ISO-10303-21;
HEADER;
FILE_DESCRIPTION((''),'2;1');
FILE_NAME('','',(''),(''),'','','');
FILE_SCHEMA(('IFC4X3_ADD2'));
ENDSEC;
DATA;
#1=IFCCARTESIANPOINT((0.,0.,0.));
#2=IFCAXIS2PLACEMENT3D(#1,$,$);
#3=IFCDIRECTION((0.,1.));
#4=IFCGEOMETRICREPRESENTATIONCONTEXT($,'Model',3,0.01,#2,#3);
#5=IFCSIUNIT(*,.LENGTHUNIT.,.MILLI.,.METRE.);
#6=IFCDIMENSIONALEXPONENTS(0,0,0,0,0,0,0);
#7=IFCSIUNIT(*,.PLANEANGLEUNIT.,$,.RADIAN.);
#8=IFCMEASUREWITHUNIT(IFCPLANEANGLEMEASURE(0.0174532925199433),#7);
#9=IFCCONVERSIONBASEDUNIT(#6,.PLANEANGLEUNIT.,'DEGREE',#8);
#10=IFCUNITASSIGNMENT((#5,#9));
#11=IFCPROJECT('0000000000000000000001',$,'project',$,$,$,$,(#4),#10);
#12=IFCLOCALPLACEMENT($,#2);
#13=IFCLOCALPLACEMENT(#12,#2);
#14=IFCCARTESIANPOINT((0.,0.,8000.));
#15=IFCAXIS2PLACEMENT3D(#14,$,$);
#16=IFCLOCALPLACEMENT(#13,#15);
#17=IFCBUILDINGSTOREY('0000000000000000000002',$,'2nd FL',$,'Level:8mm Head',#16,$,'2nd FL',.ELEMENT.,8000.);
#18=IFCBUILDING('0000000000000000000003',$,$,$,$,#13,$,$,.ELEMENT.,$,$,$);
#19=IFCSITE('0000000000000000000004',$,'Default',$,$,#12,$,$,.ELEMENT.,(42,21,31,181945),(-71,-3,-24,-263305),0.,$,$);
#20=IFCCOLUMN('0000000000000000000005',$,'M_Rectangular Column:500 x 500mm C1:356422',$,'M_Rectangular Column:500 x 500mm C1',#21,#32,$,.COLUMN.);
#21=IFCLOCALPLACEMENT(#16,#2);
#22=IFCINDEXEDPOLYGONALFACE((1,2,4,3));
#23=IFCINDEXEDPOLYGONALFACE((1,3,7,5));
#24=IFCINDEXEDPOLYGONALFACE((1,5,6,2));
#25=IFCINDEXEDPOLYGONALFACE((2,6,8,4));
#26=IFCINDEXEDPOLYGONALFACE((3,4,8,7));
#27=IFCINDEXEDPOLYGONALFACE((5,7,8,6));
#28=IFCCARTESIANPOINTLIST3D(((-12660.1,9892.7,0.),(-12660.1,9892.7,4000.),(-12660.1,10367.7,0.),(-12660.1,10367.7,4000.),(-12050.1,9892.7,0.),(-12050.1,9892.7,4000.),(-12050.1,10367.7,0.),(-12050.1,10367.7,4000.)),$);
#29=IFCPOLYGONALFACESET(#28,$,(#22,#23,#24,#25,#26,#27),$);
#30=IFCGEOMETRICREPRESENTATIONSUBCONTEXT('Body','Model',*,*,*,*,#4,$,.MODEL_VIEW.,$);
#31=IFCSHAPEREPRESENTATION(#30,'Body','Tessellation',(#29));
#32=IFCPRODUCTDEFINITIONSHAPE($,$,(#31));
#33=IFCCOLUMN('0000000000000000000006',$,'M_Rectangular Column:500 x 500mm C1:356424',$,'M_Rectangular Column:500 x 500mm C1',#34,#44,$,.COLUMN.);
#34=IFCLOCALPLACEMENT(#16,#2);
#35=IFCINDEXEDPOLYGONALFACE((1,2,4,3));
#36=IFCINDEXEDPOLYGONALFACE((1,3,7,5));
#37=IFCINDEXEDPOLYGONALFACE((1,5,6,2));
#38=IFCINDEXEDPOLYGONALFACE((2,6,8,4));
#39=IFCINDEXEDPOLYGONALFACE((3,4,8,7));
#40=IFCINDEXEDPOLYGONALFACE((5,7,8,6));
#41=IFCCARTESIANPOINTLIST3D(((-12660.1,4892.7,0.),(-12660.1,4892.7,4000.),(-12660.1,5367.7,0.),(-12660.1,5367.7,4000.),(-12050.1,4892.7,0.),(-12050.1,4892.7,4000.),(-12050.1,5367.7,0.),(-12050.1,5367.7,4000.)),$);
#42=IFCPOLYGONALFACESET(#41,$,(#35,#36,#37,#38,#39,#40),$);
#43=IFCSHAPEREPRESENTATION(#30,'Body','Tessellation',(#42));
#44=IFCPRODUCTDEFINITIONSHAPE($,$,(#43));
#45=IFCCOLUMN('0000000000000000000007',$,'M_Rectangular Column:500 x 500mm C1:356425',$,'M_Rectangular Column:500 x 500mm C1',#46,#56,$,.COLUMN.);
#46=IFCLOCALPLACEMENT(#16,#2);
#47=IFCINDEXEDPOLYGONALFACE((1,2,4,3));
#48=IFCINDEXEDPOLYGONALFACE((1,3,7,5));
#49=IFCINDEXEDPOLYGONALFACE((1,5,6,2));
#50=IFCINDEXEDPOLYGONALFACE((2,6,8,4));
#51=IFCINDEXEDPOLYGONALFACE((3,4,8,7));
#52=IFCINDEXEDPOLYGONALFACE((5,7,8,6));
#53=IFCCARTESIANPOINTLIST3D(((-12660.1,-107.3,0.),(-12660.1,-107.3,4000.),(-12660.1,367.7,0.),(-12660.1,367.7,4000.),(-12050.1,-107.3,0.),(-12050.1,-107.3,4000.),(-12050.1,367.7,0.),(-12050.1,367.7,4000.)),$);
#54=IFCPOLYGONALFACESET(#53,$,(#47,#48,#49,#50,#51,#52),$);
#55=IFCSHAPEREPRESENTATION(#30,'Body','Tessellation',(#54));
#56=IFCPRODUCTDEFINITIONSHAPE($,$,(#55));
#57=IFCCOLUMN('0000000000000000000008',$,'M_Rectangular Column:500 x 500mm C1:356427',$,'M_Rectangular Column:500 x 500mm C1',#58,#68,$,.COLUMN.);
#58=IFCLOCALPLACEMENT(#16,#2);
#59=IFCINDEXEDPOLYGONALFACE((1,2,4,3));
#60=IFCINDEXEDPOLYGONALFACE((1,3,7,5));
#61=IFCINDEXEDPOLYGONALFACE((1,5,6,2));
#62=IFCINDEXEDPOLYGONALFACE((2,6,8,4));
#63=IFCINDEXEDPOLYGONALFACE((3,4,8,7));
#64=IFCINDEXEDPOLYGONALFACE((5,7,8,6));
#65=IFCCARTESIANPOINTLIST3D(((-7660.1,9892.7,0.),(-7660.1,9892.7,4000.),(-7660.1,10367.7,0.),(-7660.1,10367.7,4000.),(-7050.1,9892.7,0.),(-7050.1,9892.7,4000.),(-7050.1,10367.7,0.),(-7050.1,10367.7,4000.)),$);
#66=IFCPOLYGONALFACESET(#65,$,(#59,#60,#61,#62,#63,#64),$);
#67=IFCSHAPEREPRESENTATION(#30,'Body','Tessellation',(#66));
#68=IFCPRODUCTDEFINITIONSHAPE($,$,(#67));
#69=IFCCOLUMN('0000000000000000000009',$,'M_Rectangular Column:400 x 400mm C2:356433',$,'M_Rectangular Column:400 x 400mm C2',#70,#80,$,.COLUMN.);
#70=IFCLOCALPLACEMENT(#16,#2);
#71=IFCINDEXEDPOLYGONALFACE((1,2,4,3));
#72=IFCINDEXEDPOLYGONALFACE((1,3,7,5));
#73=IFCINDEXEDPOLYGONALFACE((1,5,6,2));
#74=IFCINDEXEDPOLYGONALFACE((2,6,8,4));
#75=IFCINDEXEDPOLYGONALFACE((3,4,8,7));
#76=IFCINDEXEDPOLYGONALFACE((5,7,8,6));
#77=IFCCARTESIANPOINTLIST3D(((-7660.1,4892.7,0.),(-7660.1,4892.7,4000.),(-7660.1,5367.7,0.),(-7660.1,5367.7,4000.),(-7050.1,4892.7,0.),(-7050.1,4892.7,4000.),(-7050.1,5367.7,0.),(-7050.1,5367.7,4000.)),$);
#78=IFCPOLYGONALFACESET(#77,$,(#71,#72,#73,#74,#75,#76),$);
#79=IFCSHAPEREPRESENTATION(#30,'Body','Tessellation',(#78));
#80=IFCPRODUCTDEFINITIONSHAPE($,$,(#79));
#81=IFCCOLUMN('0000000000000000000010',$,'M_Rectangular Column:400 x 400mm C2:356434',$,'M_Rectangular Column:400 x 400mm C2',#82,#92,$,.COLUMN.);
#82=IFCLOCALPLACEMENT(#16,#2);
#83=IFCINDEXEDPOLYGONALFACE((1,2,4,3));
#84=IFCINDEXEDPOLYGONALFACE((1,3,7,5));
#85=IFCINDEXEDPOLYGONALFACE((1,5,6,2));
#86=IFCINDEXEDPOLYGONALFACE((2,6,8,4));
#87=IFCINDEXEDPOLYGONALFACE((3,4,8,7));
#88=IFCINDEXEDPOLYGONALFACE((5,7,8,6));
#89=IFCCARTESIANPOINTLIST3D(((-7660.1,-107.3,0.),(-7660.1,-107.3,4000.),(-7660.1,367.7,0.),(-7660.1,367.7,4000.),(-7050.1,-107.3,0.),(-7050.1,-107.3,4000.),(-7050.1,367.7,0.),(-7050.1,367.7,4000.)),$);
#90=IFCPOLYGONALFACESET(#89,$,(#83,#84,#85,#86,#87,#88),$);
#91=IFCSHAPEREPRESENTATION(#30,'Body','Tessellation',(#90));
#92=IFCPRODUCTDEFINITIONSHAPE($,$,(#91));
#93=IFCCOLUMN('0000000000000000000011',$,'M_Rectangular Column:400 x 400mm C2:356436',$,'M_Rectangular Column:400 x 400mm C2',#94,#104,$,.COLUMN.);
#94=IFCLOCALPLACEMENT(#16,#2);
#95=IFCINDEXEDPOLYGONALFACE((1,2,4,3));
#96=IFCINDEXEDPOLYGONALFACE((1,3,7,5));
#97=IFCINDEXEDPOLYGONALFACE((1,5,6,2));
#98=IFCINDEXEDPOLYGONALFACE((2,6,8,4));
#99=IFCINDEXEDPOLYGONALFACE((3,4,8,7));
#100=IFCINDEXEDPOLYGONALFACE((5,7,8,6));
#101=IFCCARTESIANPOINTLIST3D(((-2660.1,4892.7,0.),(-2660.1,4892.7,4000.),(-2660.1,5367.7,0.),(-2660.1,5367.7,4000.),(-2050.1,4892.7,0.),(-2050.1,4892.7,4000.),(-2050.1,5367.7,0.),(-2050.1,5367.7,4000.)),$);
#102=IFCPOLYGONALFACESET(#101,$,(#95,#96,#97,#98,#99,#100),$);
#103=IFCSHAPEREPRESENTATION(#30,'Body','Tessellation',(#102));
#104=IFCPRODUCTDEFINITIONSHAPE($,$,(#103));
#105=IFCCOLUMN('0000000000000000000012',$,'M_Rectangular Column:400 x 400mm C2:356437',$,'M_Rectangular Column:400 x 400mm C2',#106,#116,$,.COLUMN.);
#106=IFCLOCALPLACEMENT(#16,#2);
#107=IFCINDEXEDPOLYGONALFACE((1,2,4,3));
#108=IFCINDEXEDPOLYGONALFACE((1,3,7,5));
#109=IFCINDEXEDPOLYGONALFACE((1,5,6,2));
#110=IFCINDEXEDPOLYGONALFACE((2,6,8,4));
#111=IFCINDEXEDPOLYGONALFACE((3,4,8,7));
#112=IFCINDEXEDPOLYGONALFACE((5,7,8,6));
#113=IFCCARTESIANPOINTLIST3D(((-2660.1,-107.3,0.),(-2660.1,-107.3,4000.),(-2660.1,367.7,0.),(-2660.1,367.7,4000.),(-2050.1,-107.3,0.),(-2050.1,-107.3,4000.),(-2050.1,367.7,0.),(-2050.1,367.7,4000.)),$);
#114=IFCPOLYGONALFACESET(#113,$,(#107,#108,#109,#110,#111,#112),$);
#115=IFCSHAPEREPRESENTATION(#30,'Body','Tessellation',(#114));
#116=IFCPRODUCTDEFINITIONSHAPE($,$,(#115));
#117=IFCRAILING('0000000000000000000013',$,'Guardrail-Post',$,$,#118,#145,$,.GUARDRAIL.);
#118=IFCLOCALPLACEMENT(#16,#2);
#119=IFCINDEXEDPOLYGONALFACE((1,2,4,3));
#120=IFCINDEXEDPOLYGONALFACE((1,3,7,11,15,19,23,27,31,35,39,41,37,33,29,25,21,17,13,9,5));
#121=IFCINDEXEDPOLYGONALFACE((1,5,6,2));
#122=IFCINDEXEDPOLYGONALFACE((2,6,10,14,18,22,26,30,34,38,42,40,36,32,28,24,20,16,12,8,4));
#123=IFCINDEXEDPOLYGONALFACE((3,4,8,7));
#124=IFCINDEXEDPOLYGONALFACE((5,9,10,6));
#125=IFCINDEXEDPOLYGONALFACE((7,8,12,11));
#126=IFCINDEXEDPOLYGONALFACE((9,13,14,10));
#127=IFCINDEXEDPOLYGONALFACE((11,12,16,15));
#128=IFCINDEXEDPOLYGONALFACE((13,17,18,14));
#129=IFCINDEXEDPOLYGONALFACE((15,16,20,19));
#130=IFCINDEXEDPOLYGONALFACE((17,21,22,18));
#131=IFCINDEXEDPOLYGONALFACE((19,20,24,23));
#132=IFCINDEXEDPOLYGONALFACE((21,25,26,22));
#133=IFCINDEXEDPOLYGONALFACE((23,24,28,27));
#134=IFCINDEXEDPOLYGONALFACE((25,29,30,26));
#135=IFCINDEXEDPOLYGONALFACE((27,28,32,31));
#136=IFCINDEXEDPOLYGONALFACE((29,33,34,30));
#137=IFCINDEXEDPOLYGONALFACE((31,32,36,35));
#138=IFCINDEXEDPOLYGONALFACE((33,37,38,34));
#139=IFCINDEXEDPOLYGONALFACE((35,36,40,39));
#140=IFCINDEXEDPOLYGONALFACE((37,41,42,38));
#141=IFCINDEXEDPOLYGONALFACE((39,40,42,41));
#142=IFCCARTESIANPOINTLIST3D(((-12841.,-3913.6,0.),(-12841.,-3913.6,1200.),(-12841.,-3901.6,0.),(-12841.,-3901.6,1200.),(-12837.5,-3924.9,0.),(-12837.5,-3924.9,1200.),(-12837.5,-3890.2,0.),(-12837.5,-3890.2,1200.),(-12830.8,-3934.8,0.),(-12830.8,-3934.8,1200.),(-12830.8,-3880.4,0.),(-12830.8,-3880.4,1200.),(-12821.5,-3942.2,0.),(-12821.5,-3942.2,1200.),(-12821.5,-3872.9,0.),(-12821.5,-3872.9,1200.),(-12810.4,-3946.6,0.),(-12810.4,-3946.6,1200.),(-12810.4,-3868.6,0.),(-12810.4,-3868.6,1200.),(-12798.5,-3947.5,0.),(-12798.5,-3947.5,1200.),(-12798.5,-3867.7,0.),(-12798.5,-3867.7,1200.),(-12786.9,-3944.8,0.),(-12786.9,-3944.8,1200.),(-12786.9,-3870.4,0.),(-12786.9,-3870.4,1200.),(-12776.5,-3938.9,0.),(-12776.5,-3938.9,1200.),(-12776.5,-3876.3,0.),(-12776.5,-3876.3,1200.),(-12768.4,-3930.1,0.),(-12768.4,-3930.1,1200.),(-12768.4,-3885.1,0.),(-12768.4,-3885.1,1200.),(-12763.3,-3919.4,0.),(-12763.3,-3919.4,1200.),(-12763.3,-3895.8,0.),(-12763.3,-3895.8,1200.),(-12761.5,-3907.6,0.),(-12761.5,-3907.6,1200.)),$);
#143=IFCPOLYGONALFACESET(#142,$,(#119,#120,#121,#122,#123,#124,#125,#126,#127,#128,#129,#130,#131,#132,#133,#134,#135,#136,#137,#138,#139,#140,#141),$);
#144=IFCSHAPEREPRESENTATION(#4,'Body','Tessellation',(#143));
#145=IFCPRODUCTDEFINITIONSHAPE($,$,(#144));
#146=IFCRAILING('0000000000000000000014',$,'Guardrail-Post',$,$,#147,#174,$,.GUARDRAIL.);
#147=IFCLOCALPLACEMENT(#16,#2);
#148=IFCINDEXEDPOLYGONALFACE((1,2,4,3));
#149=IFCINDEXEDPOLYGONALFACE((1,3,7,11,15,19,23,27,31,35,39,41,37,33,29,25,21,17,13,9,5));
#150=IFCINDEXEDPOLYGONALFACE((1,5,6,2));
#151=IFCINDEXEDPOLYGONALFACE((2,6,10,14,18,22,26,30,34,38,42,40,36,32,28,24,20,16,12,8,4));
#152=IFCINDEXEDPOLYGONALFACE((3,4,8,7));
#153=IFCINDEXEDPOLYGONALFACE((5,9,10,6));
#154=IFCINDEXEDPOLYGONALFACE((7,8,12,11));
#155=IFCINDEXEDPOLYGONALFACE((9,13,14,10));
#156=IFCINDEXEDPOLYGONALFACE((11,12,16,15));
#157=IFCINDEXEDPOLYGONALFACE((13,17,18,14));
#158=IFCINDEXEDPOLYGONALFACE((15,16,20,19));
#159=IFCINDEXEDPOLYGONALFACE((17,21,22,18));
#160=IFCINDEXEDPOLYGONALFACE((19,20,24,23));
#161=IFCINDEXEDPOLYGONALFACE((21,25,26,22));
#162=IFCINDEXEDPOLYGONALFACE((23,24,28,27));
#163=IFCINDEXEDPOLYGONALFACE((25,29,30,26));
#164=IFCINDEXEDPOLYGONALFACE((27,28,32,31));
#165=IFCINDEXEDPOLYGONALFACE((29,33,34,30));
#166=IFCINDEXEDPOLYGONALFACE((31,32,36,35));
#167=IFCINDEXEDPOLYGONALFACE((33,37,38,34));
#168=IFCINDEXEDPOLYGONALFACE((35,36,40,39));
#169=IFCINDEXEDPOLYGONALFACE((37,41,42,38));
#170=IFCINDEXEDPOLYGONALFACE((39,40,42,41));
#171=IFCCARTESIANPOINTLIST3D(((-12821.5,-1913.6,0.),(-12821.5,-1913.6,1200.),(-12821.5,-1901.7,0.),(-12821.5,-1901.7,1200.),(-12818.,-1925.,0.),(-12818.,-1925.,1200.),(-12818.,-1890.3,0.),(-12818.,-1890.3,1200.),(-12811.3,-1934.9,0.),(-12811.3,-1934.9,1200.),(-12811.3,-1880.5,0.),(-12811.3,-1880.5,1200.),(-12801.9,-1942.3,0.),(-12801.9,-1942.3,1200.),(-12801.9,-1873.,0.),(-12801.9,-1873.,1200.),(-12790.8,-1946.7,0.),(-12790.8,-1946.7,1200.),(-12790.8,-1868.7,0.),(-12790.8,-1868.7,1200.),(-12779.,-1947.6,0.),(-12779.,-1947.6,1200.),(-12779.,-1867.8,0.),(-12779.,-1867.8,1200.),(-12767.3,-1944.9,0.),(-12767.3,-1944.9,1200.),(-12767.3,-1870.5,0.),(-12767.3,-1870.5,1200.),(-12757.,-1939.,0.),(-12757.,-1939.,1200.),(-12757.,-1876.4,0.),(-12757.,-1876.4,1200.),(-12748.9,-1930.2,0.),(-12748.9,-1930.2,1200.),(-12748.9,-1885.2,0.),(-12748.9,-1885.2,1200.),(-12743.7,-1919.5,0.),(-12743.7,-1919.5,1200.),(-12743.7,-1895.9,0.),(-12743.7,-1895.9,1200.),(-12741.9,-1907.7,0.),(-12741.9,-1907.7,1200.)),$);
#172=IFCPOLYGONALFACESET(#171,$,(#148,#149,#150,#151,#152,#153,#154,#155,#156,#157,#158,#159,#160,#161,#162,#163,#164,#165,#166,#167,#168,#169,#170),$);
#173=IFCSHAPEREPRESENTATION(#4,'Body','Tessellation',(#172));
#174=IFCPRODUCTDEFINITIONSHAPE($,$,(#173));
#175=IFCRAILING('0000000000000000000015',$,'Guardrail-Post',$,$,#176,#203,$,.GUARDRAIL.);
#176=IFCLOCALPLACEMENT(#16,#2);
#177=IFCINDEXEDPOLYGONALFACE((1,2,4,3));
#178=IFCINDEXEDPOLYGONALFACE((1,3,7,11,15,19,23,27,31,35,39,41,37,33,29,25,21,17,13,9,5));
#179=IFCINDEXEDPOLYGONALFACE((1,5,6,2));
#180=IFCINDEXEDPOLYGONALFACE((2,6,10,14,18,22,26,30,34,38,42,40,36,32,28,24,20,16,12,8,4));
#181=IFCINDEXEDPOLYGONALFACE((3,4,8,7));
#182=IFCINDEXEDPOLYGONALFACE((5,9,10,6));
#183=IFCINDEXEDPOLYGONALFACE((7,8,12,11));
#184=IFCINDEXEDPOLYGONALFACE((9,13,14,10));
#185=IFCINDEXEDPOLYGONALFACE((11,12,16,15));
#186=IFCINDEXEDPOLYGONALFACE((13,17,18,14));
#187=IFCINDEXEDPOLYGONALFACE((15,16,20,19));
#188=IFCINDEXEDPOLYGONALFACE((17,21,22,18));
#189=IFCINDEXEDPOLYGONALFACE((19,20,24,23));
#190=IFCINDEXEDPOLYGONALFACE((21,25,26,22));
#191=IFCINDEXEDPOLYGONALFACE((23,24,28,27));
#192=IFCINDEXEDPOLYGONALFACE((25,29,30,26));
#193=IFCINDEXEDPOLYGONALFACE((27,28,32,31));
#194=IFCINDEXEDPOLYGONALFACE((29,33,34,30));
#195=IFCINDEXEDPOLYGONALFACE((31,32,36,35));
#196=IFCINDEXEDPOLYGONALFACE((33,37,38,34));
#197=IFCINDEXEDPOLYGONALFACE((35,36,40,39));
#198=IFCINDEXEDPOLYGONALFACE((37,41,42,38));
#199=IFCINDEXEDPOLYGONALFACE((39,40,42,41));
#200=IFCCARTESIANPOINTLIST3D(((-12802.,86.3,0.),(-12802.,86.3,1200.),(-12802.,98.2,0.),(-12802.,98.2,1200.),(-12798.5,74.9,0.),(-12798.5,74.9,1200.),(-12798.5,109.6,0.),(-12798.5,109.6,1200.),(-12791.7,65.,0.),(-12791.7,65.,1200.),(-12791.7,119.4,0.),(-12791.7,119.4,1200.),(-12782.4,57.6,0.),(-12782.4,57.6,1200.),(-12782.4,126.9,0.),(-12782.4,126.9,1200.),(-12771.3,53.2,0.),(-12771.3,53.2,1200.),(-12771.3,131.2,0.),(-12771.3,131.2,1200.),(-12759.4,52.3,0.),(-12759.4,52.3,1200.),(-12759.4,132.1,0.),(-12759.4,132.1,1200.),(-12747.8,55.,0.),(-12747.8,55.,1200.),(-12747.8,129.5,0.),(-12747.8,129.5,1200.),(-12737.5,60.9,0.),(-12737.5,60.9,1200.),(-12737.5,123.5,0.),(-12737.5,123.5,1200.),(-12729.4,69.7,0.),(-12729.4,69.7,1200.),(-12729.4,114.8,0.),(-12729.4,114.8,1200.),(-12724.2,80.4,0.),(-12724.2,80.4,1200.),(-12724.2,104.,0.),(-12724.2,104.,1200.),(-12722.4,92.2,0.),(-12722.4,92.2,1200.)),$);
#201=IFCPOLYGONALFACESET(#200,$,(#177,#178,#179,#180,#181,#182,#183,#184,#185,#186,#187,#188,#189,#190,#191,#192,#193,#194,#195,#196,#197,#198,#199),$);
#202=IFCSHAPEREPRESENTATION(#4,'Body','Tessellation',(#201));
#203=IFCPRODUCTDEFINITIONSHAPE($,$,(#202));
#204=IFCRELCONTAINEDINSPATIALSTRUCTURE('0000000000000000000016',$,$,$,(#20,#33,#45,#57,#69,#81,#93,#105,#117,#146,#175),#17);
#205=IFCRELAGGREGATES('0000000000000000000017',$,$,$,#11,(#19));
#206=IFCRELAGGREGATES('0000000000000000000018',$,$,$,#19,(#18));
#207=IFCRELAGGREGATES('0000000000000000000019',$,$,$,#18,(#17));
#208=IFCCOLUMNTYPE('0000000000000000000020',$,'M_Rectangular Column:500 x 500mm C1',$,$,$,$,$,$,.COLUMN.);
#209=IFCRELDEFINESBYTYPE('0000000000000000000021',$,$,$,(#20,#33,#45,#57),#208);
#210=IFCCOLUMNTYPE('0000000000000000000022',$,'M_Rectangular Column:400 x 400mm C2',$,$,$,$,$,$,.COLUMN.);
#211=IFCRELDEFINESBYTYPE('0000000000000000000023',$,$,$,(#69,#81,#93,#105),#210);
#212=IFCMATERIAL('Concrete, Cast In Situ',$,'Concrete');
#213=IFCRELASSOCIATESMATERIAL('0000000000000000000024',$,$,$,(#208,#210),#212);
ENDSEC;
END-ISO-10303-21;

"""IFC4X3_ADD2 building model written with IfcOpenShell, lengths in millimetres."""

from ifc_helpers import new_model, entity, si_unit, converted_unit, direction, frame, frame_2d, origin, origin_with_axes, origin_2d, origin_2d_with_axis, place, context, subcontext, project, spatial, rectangle, circle, extrude, source, transform, mapped, material, material_profile, profile_set, type_object, type_shapes, element, save


model = new_model("IFC4X3_ADD2")

# Units and contexts
model_context = context("Model", 3, precision=0.01, world=origin(), true_north=direction((0.0, 1.0)))
body_context = subcontext(model_context, "Body", "Model", "MODEL_VIEW")
ifc_project = project(units=[si_unit("LENGTHUNIT", "METRE", prefix="MILLI"), converted_unit("PLANEANGLEUNIT", "DEGREE", entity("IfcPlaneAngleMeasure", 0.0174532925199433), si_unit("PLANEANGLEUNIT", "RADIAN"), dimensions=[0, 0, 0, 0, 0, 0, 0])], contexts=[model_context])

# Site, building, storey
site_placement = place(None, origin())
site = spatial("IfcSite", under=ifc_project, at=site_placement, Name="Default", CompositionType="ELEMENT", RefLatitude=(42, 21, 31, 181945), RefLongitude=(-71, -3, -24, -263305), RefElevation=0.0)
building_placement = place(site_placement, origin())
building = spatial("IfcBuilding", under=site, at=building_placement, CompositionType="ELEMENT")
storey_placement = place(building_placement, frame((0.0, 0.0, 8000.0)))
storey = spatial("IfcBuildingStorey", under=building, at=storey_placement, Name="2nd FL", ObjectType="Level:8mm Head", LongName="2nd FL", CompositionType="ELEMENT", Elevation=8000.0)

# Columns
ifc_material = material(Name="Concrete, Cast In Situ", Category="Concrete")
ifc_material_profile_1 = material_profile(ifc_material, rectangle(XDim=610.0, YDim=475.0, at=frame_2d((0.0, 0.0), x_axis=(1.0, 0.0))), Name="500 x 500mm C1")
ifc_profile_set_1 = profile_set([ifc_material_profile_1], Name="500 x 500mm C1")
column_type_1 = type_object("IfcColumnType", Name="M_Rectangular Column:500 x 500mm C1", PredefinedType="COLUMN", material=ifc_profile_set_1)
shared_shape_1 = source(origin(), body_context, "Body", "SweptSolid", [
    extrude(rectangle(XDim=610.0, YDim=475.0, at=origin_2d_with_axis()), frame((0.0, 0.0, 8000.0), z_axis=(0.0, 0.0, 1.0), x_axis=(-1.0, 0.0, 0.0)), (0.0, 0.0, 1.0), 4000.0),
])
type_shapes(column_type_1, [shared_shape_1])
for number, where, name in (
    (1, (-12355.1, 10130.2, -8000.0), "M_Rectangular Column:500 x 500mm C1:356422"),
    (2, (-12355.1, 5130.2, -8000.0), "M_Rectangular Column:500 x 500mm C1:356424"),
    (3, (-12355.1, 130.2, -8000.0), "M_Rectangular Column:500 x 500mm C1:356425"),
    (4, (-7355.1, 10130.2, -8000.0), "M_Rectangular Column:500 x 500mm C1:356427"),
):
    element("IfcColumn", number, at=place(storey_placement, frame(where)), inside=storey, type_object=column_type_1, Name=name, ObjectType="M_Rectangular Column:500 x 500mm C1", PredefinedType="COLUMN", context=body_context, shape_type="MappedRepresentation", body=[
        mapped(shared_shape_1, transform((0.0, 0.0, 0.0), scale=1.0)),
    ])
ifc_material_profile_2 = material_profile(ifc_material, rectangle(XDim=610.0, YDim=475.0, at=origin_2d_with_axis()), Name="400 x 400mm C2")
ifc_profile_set_2 = profile_set([ifc_material_profile_2], Name="400 x 400mm C2")
column_type_2 = type_object("IfcColumnType", Name="M_Rectangular Column:400 x 400mm C2", PredefinedType="COLUMN", material=ifc_profile_set_2)
shared_shape_2 = source(origin(), body_context, "Body", "SweptSolid", [
    extrude(rectangle(XDim=610.0, YDim=475.0, at=origin_2d_with_axis()), frame((0.0, 0.0, 8000.0), z_axis=(0.0, 0.0, 1.0), x_axis=(-1.0, 0.0, 0.0)), (0.0, 0.0, 1.0), 4000.0),
])
type_shapes(column_type_2, [shared_shape_2])
for number, where, name in (
    (5, (-7355.1, 5130.2, -8000.0), "M_Rectangular Column:400 x 400mm C2:356433"),
    (6, (-7355.1, 130.2, -8000.0), "M_Rectangular Column:400 x 400mm C2:356434"),
    (7, (-2355.1, 5130.2, -8000.0), "M_Rectangular Column:400 x 400mm C2:356436"),
    (8, (-2355.1, 130.2, -8000.0), "M_Rectangular Column:400 x 400mm C2:356437"),
):
    element("IfcColumn", number, at=place(storey_placement, frame(where)), inside=storey, type_object=column_type_2, Name=name, ObjectType="M_Rectangular Column:400 x 400mm C2", PredefinedType="COLUMN", context=body_context, shape_type="MappedRepresentation", body=[
        mapped(shared_shape_2, transform((0.0, 0.0, 0.0), scale=1.0)),
    ])

# Railings
for number, where, z_axis, x_axis, name in (
    (9, (-12801.5, -3907.6, 8000.0), (0.0, 0.0, 1.0), (1.0, 0.0, 0.0), "Guardrail-Post"),
    (10, (-12781.9, -1907.7, 8000.0), (0.0, 0.0, 1.0), (1.0, 0.0, 0.0), "Guardrail-Post"),
    (11, (-12762.4, 92.2, 8000.0), (0.0, 0.0, 1.0), (1.0, 0.0, 0.0), "Guardrail-Post"),
):
    element("IfcRailing", number, at=place(None, frame(where, z_axis=z_axis, x_axis=x_axis)), inside=storey, Name=name, PredefinedType="GUARDRAIL", context=model_context, shape_type="SweptSolid", body=[
        extrude(circle(Radius=40.0, at=origin_2d()), origin_with_axes(), (0.0, 0.0, 1.0), 1200.0),
    ])

save(model, "model.ifc")
